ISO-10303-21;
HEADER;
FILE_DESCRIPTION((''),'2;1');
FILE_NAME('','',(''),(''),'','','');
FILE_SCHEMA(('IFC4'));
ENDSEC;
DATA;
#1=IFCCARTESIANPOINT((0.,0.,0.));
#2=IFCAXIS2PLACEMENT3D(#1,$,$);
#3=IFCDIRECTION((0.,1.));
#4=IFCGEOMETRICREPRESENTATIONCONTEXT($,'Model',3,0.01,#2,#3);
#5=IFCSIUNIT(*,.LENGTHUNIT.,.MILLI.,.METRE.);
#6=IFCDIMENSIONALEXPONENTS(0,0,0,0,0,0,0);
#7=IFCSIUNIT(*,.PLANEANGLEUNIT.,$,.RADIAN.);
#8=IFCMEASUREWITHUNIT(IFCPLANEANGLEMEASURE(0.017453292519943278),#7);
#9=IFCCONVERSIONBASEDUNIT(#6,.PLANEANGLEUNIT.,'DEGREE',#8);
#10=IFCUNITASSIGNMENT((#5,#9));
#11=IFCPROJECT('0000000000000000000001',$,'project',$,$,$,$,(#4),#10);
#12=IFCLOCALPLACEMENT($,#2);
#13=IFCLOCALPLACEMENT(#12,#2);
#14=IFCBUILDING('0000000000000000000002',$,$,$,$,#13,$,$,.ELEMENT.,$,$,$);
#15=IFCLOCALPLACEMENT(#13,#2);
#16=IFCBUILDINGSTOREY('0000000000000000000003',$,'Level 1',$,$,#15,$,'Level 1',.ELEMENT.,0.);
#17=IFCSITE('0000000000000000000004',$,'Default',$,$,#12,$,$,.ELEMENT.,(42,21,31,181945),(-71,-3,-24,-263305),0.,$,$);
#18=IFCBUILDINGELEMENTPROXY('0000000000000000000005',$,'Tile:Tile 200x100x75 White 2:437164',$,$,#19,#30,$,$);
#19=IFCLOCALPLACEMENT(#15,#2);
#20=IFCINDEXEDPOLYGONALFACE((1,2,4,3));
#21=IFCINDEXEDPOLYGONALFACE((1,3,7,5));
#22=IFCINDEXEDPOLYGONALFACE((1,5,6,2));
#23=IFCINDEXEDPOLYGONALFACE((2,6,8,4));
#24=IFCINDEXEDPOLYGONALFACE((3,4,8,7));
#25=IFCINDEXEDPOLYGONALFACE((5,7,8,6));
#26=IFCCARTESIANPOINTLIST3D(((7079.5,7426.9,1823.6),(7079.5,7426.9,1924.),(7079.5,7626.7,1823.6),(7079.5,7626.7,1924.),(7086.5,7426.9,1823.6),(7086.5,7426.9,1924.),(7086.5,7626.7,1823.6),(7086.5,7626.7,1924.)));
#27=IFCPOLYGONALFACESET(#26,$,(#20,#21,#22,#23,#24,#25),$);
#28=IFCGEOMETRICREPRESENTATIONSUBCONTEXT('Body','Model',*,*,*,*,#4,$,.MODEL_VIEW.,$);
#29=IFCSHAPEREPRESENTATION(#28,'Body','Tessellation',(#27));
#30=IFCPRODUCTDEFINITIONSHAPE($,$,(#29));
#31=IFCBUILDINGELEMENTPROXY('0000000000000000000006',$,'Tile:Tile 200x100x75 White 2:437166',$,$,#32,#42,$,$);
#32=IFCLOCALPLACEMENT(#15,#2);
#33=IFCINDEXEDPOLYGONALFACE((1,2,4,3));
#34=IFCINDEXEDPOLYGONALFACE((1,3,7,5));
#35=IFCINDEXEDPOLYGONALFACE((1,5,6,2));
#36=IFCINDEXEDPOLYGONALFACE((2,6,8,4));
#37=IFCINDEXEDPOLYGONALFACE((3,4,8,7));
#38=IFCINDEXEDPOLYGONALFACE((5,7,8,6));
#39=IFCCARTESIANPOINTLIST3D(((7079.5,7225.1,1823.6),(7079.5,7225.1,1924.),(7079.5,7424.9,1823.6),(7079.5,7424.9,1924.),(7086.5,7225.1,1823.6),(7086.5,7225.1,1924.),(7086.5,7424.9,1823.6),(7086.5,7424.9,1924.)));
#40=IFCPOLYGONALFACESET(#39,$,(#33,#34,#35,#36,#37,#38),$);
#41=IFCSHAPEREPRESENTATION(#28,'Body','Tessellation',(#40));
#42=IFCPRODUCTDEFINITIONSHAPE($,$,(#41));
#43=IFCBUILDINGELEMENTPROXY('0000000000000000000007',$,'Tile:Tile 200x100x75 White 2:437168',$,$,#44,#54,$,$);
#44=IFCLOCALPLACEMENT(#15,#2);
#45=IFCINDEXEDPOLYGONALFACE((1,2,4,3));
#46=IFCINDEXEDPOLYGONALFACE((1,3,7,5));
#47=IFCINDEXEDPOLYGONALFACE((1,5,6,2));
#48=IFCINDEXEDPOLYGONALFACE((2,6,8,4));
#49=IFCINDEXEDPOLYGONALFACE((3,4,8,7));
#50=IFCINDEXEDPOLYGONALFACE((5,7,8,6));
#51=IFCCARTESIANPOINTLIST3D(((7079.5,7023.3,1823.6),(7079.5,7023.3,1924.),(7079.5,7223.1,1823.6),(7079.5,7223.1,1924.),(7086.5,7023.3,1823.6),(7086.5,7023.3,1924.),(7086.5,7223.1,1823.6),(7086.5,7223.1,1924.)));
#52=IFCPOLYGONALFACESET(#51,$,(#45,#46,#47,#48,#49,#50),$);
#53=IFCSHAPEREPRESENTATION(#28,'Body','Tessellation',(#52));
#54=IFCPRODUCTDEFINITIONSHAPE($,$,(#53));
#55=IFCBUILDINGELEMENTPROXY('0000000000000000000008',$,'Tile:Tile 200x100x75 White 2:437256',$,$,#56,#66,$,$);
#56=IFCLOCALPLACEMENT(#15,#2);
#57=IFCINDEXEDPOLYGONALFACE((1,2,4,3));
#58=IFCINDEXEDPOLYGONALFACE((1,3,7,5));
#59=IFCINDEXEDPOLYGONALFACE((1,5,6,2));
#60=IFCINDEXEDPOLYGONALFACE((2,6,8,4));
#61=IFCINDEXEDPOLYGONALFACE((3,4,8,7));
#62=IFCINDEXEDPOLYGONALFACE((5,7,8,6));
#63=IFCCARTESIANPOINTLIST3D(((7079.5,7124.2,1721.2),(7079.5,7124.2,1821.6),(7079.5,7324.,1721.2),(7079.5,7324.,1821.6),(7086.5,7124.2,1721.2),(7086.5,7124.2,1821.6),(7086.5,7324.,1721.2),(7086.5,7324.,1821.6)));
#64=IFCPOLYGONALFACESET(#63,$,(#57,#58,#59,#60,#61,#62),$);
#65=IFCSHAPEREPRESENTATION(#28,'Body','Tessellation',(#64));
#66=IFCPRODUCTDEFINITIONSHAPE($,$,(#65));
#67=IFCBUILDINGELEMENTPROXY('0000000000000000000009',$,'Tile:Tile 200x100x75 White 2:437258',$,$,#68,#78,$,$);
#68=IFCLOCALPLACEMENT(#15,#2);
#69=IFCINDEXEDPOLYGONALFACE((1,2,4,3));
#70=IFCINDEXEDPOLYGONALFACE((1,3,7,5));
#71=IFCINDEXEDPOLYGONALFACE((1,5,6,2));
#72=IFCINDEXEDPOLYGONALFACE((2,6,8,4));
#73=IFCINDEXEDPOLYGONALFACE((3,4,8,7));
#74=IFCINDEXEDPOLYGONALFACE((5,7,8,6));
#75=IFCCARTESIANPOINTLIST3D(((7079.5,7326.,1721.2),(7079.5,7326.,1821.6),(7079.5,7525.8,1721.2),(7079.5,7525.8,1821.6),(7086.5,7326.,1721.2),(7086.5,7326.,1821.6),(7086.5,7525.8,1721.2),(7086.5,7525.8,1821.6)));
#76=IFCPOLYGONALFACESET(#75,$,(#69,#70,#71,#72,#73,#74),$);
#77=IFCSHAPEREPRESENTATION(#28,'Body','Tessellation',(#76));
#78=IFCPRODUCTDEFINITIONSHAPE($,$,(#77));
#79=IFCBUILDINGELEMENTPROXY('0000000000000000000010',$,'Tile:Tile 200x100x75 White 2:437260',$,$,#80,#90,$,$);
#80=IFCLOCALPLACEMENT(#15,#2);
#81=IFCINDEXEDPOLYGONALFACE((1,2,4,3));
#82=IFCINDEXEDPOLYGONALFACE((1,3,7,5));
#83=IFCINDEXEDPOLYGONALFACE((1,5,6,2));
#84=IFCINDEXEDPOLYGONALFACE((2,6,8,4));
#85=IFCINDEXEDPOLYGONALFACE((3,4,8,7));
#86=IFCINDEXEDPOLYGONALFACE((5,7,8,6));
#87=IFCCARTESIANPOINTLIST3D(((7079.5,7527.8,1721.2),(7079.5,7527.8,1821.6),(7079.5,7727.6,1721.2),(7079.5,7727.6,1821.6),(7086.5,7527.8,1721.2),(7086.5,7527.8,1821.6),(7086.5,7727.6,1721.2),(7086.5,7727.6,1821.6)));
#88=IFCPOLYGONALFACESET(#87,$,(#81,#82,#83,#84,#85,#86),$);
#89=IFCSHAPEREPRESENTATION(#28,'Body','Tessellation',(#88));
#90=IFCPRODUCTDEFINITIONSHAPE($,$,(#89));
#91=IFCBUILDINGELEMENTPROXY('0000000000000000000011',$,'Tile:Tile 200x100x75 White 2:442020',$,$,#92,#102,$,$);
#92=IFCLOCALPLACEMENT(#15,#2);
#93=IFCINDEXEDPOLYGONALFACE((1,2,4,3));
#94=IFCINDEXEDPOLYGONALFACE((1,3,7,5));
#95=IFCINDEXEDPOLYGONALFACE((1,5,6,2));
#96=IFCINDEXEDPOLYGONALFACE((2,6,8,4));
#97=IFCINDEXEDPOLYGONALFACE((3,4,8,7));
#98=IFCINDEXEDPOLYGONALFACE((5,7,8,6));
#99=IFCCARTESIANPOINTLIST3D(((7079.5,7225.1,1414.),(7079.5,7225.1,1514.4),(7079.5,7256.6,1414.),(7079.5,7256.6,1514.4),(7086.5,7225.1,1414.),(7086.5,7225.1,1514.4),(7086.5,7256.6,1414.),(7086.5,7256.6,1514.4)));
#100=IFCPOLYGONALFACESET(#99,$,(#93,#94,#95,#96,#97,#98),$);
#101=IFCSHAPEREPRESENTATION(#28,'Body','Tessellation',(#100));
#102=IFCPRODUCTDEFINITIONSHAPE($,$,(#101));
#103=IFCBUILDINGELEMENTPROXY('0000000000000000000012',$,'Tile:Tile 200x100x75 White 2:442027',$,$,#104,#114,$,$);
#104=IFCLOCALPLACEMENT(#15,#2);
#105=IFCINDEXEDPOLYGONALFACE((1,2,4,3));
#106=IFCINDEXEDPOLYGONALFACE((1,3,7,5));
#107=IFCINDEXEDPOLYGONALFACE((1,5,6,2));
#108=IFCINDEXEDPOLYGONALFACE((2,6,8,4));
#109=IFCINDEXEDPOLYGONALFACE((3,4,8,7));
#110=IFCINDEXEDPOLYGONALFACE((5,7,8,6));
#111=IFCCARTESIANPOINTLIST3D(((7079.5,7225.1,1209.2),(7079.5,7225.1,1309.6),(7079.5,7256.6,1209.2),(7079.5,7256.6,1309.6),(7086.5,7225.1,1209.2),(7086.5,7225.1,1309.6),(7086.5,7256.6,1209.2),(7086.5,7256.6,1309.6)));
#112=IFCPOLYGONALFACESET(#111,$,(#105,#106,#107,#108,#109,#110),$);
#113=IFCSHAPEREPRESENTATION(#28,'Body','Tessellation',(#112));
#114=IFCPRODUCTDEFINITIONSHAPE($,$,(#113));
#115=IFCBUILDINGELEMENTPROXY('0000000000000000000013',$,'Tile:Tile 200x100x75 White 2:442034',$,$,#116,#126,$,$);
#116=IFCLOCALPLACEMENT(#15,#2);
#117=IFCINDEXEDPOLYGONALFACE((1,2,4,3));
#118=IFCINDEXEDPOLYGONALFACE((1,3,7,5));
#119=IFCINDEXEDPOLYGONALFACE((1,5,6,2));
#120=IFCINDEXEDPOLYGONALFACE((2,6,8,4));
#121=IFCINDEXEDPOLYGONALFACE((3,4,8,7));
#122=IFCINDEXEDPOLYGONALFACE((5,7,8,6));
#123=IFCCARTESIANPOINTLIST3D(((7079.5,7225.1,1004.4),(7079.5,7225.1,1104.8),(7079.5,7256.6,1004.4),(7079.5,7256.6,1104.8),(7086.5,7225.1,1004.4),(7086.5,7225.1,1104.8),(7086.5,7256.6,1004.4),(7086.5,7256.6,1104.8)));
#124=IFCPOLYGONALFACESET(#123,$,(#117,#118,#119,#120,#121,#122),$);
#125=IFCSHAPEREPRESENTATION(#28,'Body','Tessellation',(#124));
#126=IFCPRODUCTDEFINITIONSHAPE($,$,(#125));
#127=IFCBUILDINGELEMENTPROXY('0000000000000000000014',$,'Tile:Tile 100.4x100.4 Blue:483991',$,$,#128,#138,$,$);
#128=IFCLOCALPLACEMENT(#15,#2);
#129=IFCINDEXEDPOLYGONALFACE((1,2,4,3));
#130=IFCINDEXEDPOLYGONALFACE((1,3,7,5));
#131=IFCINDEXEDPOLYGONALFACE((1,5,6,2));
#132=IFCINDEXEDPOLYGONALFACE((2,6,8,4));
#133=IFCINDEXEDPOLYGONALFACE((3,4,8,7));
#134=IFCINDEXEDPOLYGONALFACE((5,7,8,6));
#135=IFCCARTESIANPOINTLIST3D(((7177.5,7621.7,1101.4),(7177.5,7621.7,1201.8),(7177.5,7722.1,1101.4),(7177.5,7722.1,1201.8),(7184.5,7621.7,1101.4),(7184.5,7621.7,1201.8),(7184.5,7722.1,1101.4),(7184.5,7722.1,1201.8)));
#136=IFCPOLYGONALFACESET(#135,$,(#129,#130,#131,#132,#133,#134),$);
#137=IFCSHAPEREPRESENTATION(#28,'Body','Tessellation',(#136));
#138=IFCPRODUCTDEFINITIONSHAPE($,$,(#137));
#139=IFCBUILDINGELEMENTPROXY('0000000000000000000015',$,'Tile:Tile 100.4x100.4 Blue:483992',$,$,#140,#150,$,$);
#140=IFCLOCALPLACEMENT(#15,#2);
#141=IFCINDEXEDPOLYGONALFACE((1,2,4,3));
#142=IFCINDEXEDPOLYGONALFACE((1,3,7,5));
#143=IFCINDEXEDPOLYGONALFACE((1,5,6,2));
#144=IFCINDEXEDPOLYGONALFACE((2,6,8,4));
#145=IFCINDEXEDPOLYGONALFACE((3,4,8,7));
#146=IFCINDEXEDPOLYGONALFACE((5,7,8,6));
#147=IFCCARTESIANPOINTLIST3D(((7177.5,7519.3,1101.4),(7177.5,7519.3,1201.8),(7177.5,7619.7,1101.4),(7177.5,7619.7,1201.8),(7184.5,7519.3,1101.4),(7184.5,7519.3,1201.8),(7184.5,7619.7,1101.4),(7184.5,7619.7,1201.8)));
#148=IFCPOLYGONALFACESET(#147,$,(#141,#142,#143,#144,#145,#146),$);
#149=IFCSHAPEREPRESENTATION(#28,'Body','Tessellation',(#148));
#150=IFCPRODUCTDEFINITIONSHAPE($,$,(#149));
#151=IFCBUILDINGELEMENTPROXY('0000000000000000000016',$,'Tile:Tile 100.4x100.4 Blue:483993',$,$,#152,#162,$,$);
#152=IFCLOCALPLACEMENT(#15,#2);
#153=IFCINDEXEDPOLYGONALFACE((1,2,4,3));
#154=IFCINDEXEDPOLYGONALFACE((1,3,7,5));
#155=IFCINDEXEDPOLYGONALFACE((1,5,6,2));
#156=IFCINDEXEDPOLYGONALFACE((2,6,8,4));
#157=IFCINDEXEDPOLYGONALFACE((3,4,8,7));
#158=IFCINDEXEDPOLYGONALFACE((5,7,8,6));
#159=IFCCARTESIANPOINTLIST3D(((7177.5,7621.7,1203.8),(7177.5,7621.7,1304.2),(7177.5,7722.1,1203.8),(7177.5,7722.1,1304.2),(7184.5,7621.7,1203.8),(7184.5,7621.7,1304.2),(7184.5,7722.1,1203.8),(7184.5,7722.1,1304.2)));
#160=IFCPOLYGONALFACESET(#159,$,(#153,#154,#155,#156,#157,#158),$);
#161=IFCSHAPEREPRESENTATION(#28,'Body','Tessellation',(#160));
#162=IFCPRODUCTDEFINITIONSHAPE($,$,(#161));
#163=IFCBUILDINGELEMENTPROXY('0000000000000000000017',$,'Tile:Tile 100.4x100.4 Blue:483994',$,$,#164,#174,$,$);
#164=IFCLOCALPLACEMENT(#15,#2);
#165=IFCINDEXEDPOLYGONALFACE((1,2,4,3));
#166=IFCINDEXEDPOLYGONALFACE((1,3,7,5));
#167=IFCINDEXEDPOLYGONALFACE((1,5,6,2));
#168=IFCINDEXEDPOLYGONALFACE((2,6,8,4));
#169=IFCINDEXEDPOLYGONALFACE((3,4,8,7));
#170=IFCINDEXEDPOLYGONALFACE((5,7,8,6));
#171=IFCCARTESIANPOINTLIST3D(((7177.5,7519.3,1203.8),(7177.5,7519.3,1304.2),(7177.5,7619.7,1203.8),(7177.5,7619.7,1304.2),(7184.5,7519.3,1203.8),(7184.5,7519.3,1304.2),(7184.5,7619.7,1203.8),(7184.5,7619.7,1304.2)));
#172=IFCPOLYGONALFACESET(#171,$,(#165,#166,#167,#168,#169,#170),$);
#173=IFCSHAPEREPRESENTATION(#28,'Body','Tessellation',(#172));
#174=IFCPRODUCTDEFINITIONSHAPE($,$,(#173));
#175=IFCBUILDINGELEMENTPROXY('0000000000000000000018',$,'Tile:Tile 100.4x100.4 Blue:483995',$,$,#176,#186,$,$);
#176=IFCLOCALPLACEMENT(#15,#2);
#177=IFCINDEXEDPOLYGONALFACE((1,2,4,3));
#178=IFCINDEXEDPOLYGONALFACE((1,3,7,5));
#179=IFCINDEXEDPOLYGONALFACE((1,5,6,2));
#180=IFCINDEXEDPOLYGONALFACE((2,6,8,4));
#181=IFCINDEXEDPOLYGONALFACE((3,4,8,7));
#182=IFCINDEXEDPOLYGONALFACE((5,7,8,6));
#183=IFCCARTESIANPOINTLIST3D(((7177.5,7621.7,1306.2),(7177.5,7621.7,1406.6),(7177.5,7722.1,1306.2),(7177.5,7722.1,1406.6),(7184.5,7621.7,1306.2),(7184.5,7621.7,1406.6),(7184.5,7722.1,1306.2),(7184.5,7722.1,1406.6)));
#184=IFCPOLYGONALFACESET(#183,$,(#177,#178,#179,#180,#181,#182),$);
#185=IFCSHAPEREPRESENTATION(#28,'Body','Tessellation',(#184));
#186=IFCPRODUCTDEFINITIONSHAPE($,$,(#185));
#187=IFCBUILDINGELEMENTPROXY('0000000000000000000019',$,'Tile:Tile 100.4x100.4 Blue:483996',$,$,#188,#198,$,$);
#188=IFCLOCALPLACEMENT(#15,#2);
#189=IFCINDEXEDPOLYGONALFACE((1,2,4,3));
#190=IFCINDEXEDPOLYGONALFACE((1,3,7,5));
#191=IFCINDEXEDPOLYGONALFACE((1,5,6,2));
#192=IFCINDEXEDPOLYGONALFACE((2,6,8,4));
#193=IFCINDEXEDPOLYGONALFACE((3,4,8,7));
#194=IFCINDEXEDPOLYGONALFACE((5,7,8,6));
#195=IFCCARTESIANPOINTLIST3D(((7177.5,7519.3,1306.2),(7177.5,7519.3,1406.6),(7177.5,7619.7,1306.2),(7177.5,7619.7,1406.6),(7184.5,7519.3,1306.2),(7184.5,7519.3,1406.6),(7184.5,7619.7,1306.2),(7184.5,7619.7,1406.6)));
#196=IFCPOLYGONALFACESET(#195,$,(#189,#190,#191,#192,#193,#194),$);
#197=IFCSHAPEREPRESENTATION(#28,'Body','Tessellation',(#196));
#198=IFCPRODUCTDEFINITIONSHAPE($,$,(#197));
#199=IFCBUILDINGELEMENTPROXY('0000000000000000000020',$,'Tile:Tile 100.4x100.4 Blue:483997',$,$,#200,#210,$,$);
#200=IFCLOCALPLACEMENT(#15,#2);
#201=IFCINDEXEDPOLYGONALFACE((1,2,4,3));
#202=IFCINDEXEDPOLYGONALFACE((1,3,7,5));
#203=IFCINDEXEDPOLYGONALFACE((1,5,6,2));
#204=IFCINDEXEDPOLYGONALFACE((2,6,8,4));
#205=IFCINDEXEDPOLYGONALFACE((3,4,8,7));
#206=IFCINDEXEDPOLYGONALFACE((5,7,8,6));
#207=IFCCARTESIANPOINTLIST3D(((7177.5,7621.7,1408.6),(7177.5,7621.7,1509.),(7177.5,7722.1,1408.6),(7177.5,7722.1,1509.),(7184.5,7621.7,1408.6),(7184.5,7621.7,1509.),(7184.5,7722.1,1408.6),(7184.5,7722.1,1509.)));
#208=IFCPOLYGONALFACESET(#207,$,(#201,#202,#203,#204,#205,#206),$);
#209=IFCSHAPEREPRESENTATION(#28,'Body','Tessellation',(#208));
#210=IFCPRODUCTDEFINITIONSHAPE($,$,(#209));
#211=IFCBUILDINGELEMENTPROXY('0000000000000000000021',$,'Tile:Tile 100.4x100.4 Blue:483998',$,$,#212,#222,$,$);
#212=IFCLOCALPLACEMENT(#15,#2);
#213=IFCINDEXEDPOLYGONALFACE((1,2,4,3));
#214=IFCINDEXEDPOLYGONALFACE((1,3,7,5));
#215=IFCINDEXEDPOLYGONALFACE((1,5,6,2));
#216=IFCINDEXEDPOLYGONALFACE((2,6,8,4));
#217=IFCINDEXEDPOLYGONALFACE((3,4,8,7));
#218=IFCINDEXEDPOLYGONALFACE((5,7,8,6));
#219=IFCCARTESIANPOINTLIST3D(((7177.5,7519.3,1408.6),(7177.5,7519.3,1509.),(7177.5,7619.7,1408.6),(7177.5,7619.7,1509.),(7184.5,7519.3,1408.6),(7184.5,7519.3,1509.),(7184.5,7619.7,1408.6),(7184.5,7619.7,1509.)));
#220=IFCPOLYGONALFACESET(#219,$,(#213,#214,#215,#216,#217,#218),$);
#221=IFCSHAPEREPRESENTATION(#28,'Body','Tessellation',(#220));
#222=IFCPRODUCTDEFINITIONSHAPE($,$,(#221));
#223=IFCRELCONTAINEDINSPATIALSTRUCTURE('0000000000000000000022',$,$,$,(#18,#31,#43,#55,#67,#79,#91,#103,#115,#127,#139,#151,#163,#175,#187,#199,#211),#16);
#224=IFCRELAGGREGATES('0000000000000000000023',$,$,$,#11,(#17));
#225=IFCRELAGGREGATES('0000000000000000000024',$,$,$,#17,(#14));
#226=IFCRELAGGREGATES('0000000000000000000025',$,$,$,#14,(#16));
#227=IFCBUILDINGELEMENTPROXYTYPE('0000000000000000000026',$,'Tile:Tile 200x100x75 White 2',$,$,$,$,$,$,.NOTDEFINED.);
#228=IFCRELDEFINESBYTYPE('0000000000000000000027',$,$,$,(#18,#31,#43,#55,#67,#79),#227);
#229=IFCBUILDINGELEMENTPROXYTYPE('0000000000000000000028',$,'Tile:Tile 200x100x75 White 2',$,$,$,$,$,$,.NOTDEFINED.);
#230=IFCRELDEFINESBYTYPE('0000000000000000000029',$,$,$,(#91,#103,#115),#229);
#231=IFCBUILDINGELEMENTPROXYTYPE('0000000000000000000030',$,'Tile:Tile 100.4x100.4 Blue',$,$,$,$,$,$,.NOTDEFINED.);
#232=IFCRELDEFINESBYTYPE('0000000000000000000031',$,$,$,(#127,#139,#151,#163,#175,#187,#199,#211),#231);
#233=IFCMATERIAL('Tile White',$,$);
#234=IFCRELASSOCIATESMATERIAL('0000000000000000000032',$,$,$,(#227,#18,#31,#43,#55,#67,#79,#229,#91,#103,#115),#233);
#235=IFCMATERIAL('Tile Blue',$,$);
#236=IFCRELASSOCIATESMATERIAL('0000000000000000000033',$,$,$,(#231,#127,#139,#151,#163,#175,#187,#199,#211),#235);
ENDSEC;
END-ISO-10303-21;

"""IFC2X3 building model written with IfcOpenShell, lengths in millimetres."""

from ifc_helpers import new_model, entity, si_unit, converted_unit, direction, frame, frame_2d, origin, origin_2d_with_axis, place, context, subcontext, project, spatial, rectangle, extrude, source, transform, mapped, material, type_object, type_shapes, element, save


model = new_model("IFC2X3")

# Units and contexts
model_context = context("Model", 3, precision=0.01, world=origin(), true_north=direction((0.0, 1.0)))
body_context = subcontext(model_context, "Body", "Model", "MODEL_VIEW")
ifc_project = project(units=[si_unit("LENGTHUNIT", "METRE", prefix="MILLI"), converted_unit("PLANEANGLEUNIT", "DEGREE", entity("IfcPlaneAngleMeasure", 0.017453292519943278), si_unit("PLANEANGLEUNIT", "RADIAN"), dimensions=[0, 0, 0, 0, 0, 0, 0])], contexts=[model_context])

# Site, building, storey
site_placement = place(None, origin())
site = spatial("IfcSite", under=ifc_project, at=site_placement, Name="Default", CompositionType="ELEMENT", RefLatitude=(42, 21, 31, 181945), RefLongitude=(-71, -3, -24, -263305), RefElevation=0.0)
building_placement = place(site_placement, origin())
building = spatial("IfcBuilding", under=site, at=building_placement, CompositionType="ELEMENT")
storey_placement = place(building_placement, origin())
storey = spatial("IfcBuildingStorey", under=building, at=storey_placement, Name="Level 1", LongName="Level 1", CompositionType="ELEMENT", Elevation=0.0)

# Building element proxies
ifc_material_1 = material(Name="Tile White")
building_element_proxy_type_1 = type_object("IfcBuildingElementProxyType", Name="Tile:Tile 200x100x75 White 2", PredefinedType="NOTDEFINED", material=ifc_material_1)
shared_shape_1 = source(origin(), body_context, "Body", "SweptSolid", [
    extrude(rectangle(XDim=199.8, YDim=100.4, at=frame_2d((0.0, 0.0), x_axis=(1.0, 0.0))), frame((-50.2, -99.9, 0.0), z_axis=(0.0, 0.0, 1.0), x_axis=(0.0, -1.0, 0.0)), (0.0, 0.0, 1.0), 7.0),
])
type_shapes(building_element_proxy_type_1, [shared_shape_1])
for number, where, z_axis, x_axis, name in (
    (1, (7086.5, 7626.7, 1924.0), (-1.0, 0.0, 0.0), (0.0, 0.0, 1.0), "Tile:Tile 200x100x75 White 2:437164"),
    (2, (7086.5, 7424.9, 1924.0), (-1.0, 0.0, 0.0), (0.0, 0.0, 1.0), "Tile:Tile 200x100x75 White 2:437166"),
    (3, (7086.5, 7223.1, 1924.0), (-1.0, 0.0, 0.0), (0.0, 0.0, 1.0), "Tile:Tile 200x100x75 White 2:437168"),
    (4, (7086.5, 7324.0, 1821.6), (-1.0, 0.0, 0.0), (0.0, 0.0, 1.0), "Tile:Tile 200x100x75 White 2:437256"),
    (5, (7086.5, 7525.8, 1821.6), (-1.0, 0.0, 0.0), (0.0, 0.0, 1.0), "Tile:Tile 200x100x75 White 2:437258"),
    (6, (7086.5, 7727.6, 1821.6), (-1.0, 0.0, 0.0), (0.0, 0.0, 1.0), "Tile:Tile 200x100x75 White 2:437260"),
):
    element("IfcBuildingElementProxy", number, at=place(storey_placement, frame(where, z_axis=z_axis, x_axis=x_axis)), inside=storey, type_object=building_element_proxy_type_1, material=ifc_material_1, Name=name, context=body_context, shape_type="MappedRepresentation", body=[
        mapped(shared_shape_1, transform((0.0, 0.0, 0.0), scale=1.0)),
    ])
building_element_proxy_type_2 = type_object("IfcBuildingElementProxyType", Name="Tile:Tile 200x100x75 White 2", PredefinedType="NOTDEFINED", material=ifc_material_1)
shared_shape_2 = source(origin(), body_context, "Body", "SweptSolid", [
    extrude(rectangle(XDim=100.4, YDim=31.5, at=origin_2d_with_axis()), frame((-50.2, 15.8, 0.0)), (0.0, 0.0, 1.0), 7.0),
])
type_shapes(building_element_proxy_type_2, [shared_shape_2])
for number, where, z_axis, x_axis, name in (
    (7, (7086.5, 7225.1, 1514.4), (-1.0, 0.0, 0.0), (0.0, 0.0, 1.0), "Tile:Tile 200x100x75 White 2:442020"),
    (8, (7086.5, 7225.1, 1309.6), (-1.0, 0.0, 0.0), (0.0, 0.0, 1.0), "Tile:Tile 200x100x75 White 2:442027"),
    (9, (7086.5, 7225.1, 1104.8), (-1.0, 0.0, 0.0), (0.0, 0.0, 1.0), "Tile:Tile 200x100x75 White 2:442034"),
):
    element("IfcBuildingElementProxy", number, at=place(storey_placement, frame(where, z_axis=z_axis, x_axis=x_axis)), inside=storey, type_object=building_element_proxy_type_2, material=ifc_material_1, Name=name, context=body_context, shape_type="MappedRepresentation", body=[
        mapped(shared_shape_2, transform((0.0, 0.0, 0.0), scale=1.0)),
    ])
ifc_material_2 = material(Name="Tile Blue")
building_element_proxy_type_3 = type_object("IfcBuildingElementProxyType", Name="Tile:Tile 100.4x100.4 Blue", PredefinedType="NOTDEFINED", material=ifc_material_2)
shared_shape_3 = source(origin(), body_context, "Body", "SweptSolid", [
    extrude(rectangle(XDim=100.4, YDim=100.4, at=origin_2d_with_axis()), frame((-50.2, -50.2, 0.0), z_axis=(0.0, 0.0, 1.0), x_axis=(0.0, -1.0, 0.0)), (0.0, 0.0, 1.0), 7.0),
])
type_shapes(building_element_proxy_type_3, [shared_shape_3])
for number, where, z_axis, x_axis, name in (
    (10, (7184.5, 7722.1, 1101.4), (-1.0, 0.0, 0.0), (0.0, 1.0, 0.0), "Tile:Tile 100.4x100.4 Blue:483991"),
    (11, (7184.5, 7619.7, 1101.4), (-1.0, 0.0, 0.0), (0.0, 1.0, 0.0), "Tile:Tile 100.4x100.4 Blue:483992"),
    (12, (7184.5, 7722.1, 1203.8), (-1.0, 0.0, 0.0), (0.0, 1.0, 0.0), "Tile:Tile 100.4x100.4 Blue:483993"),
    (13, (7184.5, 7619.7, 1203.8), (-1.0, 0.0, 0.0), (0.0, 1.0, 0.0), "Tile:Tile 100.4x100.4 Blue:483994"),
    (14, (7184.5, 7722.1, 1306.2), (-1.0, 0.0, 0.0), (0.0, 1.0, 0.0), "Tile:Tile 100.4x100.4 Blue:483995"),
    (15, (7184.5, 7619.7, 1306.2), (-1.0, 0.0, 0.0), (0.0, 1.0, 0.0), "Tile:Tile 100.4x100.4 Blue:483996"),
    (16, (7184.5, 7722.1, 1408.6), (-1.0, 0.0, 0.0), (0.0, 1.0, 0.0), "Tile:Tile 100.4x100.4 Blue:483997"),
    (17, (7184.5, 7619.7, 1408.6), (-1.0, 0.0, 0.0), (0.0, 1.0, 0.0), "Tile:Tile 100.4x100.4 Blue:483998"),
):
    element("IfcBuildingElementProxy", number, at=place(storey_placement, frame(where, z_axis=z_axis, x_axis=x_axis)), inside=storey, type_object=building_element_proxy_type_3, material=ifc_material_2, Name=name, context=body_context, shape_type="MappedRepresentation", body=[
        mapped(shared_shape_3, transform((0.0, 0.0, 0.0), scale=1.0)),
    ])

save(model, "model.ifc")
